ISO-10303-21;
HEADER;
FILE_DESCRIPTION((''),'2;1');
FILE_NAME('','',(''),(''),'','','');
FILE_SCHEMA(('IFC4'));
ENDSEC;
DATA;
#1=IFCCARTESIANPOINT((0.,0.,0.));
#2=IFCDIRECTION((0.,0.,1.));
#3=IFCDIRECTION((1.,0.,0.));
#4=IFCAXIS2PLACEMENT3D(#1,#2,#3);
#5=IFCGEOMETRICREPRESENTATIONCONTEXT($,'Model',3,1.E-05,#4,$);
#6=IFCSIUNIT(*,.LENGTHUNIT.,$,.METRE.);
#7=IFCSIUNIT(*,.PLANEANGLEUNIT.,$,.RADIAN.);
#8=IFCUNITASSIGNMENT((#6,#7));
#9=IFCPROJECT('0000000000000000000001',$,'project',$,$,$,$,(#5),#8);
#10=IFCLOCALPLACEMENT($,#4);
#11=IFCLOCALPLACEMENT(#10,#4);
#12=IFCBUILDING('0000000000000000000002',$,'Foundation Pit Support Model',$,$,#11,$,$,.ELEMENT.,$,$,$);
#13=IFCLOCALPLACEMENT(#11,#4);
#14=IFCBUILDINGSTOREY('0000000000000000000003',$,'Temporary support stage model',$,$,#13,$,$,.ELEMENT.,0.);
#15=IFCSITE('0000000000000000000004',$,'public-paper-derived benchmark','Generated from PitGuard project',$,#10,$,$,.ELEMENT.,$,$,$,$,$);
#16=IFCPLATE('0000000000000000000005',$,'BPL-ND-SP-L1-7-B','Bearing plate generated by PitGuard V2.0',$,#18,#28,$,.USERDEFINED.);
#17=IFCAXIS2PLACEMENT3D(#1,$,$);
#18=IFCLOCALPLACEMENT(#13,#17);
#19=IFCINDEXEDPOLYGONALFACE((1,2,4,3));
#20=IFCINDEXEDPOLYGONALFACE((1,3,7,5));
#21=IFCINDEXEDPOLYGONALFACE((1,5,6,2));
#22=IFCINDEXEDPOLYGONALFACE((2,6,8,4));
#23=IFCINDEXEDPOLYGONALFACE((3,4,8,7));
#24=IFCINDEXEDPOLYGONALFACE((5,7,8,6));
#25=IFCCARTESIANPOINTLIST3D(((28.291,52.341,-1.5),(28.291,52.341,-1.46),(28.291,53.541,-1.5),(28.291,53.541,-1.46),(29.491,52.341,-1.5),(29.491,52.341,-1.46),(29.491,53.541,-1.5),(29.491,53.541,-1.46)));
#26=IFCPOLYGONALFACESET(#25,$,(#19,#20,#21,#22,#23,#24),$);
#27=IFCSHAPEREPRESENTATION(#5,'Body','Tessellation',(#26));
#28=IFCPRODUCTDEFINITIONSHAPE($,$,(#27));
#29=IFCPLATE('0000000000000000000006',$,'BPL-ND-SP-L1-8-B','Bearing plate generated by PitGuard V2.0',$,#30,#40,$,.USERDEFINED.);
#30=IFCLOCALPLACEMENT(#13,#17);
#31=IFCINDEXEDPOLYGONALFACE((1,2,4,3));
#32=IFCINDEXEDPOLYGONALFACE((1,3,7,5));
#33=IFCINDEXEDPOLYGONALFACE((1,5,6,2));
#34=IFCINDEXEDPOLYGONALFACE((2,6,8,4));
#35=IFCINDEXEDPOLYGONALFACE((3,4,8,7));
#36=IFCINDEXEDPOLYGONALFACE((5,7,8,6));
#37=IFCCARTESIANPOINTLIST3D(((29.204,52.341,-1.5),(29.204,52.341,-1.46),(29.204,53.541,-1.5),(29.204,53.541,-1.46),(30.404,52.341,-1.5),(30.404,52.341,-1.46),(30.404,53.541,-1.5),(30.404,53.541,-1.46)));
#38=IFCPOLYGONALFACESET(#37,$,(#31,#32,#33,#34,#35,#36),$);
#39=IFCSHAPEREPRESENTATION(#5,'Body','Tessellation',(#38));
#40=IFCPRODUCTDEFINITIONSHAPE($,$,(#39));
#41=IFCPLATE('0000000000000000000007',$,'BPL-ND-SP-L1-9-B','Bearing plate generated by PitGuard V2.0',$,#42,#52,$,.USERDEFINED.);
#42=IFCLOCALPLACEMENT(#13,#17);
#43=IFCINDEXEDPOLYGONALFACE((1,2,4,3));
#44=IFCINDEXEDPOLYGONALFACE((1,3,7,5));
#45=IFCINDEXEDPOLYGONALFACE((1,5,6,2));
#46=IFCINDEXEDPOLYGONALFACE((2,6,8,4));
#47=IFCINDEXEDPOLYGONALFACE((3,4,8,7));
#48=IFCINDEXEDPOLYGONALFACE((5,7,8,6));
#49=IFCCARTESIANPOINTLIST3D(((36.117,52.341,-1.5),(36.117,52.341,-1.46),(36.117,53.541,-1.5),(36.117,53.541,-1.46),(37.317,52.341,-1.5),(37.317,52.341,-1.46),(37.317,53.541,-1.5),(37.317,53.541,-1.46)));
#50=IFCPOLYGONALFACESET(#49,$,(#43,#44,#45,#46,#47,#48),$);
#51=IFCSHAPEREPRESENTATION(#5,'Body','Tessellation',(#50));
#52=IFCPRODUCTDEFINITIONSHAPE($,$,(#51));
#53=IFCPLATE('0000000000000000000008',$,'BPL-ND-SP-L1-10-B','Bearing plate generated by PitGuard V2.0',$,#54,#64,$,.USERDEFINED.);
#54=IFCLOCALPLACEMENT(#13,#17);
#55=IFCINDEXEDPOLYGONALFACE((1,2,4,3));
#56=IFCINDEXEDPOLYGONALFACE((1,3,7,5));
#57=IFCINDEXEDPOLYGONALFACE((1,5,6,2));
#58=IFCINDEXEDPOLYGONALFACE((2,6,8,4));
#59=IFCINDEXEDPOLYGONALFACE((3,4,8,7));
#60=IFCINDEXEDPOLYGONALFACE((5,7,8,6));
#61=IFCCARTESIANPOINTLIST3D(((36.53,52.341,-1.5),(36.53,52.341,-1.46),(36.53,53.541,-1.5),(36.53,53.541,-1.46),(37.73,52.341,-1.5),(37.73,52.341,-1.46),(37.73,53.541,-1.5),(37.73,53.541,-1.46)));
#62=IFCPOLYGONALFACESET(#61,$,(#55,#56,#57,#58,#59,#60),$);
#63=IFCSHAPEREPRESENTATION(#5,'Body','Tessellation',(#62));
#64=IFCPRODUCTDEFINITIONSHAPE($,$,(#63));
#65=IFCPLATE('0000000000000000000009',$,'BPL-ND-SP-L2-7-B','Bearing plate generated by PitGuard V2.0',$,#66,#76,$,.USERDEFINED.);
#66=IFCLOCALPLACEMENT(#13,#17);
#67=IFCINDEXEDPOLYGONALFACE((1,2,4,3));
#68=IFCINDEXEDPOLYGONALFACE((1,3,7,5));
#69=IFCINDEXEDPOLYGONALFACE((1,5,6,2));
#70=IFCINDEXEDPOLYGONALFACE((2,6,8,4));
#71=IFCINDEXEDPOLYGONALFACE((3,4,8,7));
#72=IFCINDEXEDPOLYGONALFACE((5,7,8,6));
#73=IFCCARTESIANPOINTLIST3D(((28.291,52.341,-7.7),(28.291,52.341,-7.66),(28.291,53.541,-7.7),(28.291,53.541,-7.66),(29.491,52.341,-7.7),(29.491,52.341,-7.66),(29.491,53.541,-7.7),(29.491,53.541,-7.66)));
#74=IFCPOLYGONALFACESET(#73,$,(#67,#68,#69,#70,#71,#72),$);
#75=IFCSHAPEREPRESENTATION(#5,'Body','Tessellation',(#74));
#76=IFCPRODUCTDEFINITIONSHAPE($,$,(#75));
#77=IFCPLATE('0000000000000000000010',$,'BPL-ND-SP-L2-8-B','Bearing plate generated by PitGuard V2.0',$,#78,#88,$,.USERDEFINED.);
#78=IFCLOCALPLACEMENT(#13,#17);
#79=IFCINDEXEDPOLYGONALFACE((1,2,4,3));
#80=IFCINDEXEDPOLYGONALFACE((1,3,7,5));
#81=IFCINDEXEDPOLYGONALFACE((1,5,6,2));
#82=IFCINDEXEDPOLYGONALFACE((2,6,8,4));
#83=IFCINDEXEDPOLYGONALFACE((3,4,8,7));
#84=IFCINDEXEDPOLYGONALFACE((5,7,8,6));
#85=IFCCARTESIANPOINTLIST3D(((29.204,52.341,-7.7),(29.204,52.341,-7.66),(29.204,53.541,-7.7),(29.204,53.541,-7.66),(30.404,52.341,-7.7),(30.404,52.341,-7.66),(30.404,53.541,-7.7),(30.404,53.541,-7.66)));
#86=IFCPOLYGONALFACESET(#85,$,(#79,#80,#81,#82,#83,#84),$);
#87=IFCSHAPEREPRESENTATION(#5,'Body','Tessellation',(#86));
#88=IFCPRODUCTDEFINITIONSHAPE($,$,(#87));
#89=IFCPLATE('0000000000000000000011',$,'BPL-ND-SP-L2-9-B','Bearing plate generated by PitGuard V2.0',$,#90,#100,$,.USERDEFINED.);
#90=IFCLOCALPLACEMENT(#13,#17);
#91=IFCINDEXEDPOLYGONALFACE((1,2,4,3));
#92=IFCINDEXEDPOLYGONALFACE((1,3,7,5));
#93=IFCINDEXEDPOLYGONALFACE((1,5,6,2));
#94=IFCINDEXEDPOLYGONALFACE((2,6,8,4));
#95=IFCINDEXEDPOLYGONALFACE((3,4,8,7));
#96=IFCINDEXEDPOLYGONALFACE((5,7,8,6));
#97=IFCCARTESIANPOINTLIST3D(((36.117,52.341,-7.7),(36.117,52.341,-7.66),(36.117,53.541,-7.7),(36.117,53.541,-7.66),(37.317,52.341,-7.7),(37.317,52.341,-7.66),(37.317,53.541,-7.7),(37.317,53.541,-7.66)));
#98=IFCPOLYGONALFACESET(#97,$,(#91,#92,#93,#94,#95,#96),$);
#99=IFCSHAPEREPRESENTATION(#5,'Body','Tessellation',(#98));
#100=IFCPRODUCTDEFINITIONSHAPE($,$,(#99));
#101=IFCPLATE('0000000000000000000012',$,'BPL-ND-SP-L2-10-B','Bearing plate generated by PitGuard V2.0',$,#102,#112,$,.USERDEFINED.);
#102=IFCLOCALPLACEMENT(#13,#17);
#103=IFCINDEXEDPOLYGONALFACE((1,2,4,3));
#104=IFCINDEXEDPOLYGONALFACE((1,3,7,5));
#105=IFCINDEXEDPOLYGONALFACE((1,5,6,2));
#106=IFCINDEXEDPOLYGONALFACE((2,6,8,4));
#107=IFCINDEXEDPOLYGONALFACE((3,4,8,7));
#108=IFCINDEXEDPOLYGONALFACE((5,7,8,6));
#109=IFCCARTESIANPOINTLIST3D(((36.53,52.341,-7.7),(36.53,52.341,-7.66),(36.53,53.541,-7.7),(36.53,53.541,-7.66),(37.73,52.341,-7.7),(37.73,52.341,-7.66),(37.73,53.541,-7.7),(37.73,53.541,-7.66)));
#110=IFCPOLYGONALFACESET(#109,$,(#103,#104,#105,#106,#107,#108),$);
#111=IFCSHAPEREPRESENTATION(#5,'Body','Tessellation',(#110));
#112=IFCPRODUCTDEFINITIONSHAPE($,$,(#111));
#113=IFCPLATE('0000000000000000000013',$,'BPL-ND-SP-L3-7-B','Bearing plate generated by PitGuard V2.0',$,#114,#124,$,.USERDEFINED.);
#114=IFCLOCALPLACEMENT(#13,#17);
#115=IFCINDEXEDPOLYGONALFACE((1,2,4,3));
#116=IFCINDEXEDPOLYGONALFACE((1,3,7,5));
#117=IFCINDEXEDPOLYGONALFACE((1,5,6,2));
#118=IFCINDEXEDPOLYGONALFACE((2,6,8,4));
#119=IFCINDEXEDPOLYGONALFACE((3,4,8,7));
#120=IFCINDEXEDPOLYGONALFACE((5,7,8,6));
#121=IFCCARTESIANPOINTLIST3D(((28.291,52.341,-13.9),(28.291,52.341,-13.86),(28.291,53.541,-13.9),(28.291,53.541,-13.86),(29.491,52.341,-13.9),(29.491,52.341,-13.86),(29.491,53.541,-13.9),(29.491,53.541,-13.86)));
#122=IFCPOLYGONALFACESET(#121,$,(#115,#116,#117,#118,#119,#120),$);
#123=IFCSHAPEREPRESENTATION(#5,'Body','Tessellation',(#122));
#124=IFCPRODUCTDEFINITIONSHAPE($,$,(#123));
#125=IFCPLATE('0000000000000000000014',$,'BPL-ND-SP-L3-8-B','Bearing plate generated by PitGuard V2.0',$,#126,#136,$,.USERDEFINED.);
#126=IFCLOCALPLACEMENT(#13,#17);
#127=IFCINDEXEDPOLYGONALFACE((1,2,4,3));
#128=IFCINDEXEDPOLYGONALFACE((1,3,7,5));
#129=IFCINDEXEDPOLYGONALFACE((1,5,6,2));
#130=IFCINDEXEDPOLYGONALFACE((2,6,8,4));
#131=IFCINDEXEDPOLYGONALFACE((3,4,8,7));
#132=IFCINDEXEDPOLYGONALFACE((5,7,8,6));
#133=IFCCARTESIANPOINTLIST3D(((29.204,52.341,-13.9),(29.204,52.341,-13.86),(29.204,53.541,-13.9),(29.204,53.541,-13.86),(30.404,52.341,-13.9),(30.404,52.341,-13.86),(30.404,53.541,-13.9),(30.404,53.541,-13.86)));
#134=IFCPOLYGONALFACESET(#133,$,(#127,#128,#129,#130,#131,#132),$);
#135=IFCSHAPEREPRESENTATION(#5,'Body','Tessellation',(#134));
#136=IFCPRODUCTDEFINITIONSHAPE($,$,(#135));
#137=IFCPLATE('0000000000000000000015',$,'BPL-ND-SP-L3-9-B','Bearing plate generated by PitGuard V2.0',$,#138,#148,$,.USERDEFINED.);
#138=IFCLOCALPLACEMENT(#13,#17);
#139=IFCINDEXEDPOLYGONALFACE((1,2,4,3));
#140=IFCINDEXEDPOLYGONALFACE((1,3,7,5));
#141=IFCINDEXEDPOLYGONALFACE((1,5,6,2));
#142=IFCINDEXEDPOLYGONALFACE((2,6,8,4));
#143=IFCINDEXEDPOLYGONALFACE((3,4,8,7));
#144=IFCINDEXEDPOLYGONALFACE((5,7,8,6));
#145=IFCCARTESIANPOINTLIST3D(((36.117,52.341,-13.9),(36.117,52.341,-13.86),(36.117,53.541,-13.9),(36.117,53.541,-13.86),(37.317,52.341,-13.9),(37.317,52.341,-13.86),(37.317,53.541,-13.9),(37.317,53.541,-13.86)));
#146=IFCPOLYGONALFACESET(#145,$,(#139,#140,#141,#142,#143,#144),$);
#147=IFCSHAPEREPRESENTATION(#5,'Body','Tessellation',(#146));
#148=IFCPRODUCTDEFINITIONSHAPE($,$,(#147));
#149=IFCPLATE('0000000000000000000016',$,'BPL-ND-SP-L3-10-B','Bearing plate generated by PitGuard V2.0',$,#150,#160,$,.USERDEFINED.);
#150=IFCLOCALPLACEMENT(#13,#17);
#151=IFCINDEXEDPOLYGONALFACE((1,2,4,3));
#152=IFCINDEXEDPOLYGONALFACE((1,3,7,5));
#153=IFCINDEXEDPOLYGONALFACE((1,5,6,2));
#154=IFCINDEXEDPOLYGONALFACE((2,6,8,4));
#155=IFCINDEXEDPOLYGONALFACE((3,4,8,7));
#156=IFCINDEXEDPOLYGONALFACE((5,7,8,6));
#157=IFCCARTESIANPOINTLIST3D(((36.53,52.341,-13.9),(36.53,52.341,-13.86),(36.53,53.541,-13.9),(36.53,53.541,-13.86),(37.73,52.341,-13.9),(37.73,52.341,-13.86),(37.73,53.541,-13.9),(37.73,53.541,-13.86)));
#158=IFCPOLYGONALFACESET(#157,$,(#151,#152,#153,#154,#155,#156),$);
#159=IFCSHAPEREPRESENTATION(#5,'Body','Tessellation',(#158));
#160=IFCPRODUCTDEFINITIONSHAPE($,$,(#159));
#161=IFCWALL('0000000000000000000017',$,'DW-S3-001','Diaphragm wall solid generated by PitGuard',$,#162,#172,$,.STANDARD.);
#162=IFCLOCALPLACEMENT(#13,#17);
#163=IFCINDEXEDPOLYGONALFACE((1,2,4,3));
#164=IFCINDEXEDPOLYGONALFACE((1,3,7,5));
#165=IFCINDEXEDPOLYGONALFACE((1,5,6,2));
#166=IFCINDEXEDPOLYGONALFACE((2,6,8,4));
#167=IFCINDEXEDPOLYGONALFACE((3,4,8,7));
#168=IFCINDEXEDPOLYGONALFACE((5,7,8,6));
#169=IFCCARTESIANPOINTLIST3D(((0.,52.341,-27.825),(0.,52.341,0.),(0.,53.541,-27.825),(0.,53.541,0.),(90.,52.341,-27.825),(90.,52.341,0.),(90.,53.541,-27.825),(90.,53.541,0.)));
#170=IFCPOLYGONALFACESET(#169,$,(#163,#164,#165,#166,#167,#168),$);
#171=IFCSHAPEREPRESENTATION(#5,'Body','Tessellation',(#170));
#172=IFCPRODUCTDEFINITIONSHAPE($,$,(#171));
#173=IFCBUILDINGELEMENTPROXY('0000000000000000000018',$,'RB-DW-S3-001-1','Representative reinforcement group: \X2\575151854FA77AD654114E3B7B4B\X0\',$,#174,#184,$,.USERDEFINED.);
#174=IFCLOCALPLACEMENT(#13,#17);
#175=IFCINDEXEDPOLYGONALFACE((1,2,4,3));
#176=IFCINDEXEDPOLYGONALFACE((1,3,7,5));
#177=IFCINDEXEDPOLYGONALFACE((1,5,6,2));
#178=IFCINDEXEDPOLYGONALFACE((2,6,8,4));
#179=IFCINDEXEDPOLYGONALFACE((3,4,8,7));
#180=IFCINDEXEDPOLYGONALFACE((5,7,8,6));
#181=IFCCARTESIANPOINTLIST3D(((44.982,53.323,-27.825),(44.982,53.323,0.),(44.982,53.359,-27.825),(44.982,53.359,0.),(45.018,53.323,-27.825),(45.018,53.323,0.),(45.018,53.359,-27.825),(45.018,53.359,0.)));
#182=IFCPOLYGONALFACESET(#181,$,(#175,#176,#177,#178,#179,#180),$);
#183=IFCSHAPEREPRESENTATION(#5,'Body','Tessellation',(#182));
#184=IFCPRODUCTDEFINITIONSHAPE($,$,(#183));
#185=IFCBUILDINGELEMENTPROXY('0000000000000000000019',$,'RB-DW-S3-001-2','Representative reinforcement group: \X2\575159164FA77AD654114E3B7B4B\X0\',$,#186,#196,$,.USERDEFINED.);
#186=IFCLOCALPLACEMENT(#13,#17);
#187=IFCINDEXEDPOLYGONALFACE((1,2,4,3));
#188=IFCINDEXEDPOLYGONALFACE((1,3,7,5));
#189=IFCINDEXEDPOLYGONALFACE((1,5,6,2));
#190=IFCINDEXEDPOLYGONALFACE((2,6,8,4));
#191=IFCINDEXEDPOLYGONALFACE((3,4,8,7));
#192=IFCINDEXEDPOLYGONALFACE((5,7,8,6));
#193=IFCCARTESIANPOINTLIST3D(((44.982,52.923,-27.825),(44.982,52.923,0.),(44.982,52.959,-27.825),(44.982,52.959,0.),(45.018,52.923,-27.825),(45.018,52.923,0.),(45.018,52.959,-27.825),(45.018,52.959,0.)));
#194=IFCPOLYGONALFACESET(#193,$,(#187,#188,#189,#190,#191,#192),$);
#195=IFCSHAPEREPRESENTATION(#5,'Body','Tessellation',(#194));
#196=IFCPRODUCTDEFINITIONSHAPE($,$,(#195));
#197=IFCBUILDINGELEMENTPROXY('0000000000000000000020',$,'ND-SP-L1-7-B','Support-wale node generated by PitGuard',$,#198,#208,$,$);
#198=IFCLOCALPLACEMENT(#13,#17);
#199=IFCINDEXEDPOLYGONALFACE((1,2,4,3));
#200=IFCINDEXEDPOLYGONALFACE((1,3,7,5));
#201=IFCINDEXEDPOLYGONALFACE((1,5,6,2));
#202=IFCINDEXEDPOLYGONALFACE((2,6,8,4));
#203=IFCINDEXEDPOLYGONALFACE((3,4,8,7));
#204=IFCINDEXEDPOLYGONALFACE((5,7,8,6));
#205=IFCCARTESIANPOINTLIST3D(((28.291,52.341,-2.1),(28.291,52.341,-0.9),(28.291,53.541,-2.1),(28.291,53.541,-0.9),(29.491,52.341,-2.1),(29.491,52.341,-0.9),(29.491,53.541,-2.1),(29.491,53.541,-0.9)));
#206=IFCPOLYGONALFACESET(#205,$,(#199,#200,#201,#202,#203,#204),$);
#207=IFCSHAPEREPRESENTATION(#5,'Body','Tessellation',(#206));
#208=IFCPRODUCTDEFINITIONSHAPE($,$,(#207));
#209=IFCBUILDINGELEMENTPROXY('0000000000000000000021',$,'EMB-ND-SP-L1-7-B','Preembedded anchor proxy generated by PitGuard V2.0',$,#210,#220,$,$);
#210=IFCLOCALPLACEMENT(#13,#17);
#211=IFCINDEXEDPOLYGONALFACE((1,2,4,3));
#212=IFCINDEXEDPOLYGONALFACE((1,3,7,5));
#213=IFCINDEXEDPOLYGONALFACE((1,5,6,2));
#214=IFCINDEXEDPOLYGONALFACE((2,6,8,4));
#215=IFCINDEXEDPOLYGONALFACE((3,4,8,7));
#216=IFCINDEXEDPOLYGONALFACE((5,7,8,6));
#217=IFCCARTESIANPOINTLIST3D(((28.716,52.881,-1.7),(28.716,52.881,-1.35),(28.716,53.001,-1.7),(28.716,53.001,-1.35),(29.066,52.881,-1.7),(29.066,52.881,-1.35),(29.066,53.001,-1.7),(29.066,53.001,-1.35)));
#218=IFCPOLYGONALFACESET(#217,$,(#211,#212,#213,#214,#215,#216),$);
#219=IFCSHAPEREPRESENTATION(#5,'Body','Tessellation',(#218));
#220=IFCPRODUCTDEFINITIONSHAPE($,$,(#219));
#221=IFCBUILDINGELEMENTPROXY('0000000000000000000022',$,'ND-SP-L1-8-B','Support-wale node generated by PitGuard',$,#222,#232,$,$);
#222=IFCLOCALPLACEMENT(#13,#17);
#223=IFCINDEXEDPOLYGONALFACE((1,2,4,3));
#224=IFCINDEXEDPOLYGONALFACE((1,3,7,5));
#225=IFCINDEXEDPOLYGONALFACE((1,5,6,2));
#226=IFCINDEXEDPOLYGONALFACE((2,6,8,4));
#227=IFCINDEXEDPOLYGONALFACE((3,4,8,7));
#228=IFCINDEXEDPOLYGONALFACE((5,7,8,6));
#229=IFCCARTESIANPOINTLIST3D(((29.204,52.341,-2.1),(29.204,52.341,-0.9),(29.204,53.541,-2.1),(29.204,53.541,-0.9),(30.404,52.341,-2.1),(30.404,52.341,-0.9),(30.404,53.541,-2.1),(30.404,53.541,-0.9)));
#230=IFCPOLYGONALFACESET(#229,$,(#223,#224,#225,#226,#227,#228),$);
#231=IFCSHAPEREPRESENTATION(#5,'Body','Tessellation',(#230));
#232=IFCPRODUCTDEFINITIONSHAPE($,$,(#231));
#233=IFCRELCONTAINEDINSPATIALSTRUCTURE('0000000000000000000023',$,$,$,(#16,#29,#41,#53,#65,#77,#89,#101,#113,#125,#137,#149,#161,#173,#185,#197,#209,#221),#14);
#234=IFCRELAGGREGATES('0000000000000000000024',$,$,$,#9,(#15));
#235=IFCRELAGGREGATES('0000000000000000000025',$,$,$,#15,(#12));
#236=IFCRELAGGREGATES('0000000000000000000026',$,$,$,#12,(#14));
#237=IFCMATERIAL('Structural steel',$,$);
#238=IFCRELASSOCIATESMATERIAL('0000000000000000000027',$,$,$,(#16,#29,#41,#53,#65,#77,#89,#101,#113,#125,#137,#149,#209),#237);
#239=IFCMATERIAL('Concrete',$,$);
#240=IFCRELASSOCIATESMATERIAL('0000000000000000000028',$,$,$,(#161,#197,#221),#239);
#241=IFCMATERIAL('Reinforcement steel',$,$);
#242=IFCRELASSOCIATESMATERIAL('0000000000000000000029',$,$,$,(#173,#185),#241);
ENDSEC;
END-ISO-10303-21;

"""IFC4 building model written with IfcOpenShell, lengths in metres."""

from ifc_helpers import new_model, si_unit, frame, origin_with_axes, origin_2d, place, context, project, spatial, rectangle, extrude, material, element, save


model = new_model("IFC4")

# Units and contexts
model_context = context("Model", 3, precision=1e-05, world=origin_with_axes())
ifc_project = project(units=[si_unit("LENGTHUNIT", "METRE"), si_unit("PLANEANGLEUNIT", "RADIAN")], contexts=[model_context])

# Site, building, storey
site_placement = place(None, origin_with_axes())
site = spatial("IfcSite", under=ifc_project, at=site_placement, Name="public-paper-derived benchmark", Description="Generated from PitGuard project", CompositionType="ELEMENT")
building_placement = place(site_placement, origin_with_axes())
building = spatial("IfcBuilding", under=site, at=building_placement, Name="Foundation Pit Support Model", CompositionType="ELEMENT")
storey_placement = place(building_placement, origin_with_axes())
storey = spatial("IfcBuildingStorey", under=building, at=storey_placement, Name="Temporary support stage model", CompositionType="ELEMENT", Elevation=0.0)

# Plates
ifc_material_1 = material(Name="Structural steel")
for number, where, z_axis, x_axis, name in (
    (1, (28.891, 52.941, -1.5), (0.0, 0.0, 1.0), (1.0, 0.0, 0.0), "BPL-ND-SP-L1-7-B"),
    (2, (29.804, 52.941, -1.5), (0.0, 0.0, 1.0), (1.0, 0.0, 0.0), "BPL-ND-SP-L1-8-B"),
    (3, (36.717, 52.941, -1.5), (0.0, 0.0, 1.0), (1.0, 0.0, 0.0), "BPL-ND-SP-L1-9-B"),
    (4, (37.13, 52.941, -1.5), (0.0, 0.0, 1.0), (1.0, 0.0, 0.0), "BPL-ND-SP-L1-10-B"),
    (5, (28.891, 52.941, -7.7), (0.0, 0.0, 1.0), (1.0, 0.0, 0.0), "BPL-ND-SP-L2-7-B"),
    (6, (29.804, 52.941, -7.7), (0.0, 0.0, 1.0), (1.0, 0.0, 0.0), "BPL-ND-SP-L2-8-B"),
    (7, (36.717, 52.941, -7.7), (0.0, 0.0, 1.0), (1.0, 0.0, 0.0), "BPL-ND-SP-L2-9-B"),
    (8, (37.13, 52.941, -7.7), (0.0, 0.0, 1.0), (1.0, 0.0, 0.0), "BPL-ND-SP-L2-10-B"),
    (9, (28.891, 52.941, -13.9), (0.0, 0.0, 1.0), (1.0, 0.0, 0.0), "BPL-ND-SP-L3-7-B"),
    (10, (29.804, 52.941, -13.9), (0.0, 0.0, 1.0), (1.0, 0.0, 0.0), "BPL-ND-SP-L3-8-B"),
    (11, (36.717, 52.941, -13.9), (0.0, 0.0, 1.0), (1.0, 0.0, 0.0), "BPL-ND-SP-L3-9-B"),
    (12, (37.13, 52.941, -13.9), (0.0, 0.0, 1.0), (1.0, 0.0, 0.0), "BPL-ND-SP-L3-10-B"),
):
    element("IfcPlate", number, at=place(storey_placement, frame(where, z_axis=z_axis, x_axis=x_axis)), inside=storey, material=ifc_material_1, Name=name, Description="Bearing plate generated by PitGuard V2.0", PredefinedType="USERDEFINED", context=model_context, shape_type="SweptSolid", body=[
        extrude(rectangle(XDim=1.2, YDim=1.2, at=origin_2d()), origin_with_axes(), (0.0, 0.0, 1.0), 0.04),
    ])

# Wall
ifc_material_2 = material(Name="Concrete")
wall_placement = place(storey_placement, frame((45.0, 52.941, -27.825), z_axis=(0.0, 0.0, 1.0), x_axis=(-1.0, 0.0, 0.0)))
element("IfcWall", 13, at=wall_placement, inside=storey, material=ifc_material_2, Name="DW-S3-001", Description="Diaphragm wall solid generated by PitGuard", PredefinedType="STANDARD", context=model_context, shape_type="SweptSolid", body=[
    extrude(rectangle(XDim=90.0, YDim=1.2, at=origin_2d()), origin_with_axes(), (0.0, 0.0, 1.0), 27.825),
])

# Building element proxies
ifc_material_3 = material(Name="Reinforcement steel")
for number, where, z_axis, x_axis, name, description in (
    (14, (45.0, 53.341, -27.825), (0.0, 0.0, 1.0), (1.0, 0.0, 0.0), "RB-DW-S3-001-1", "Representative reinforcement group: 坑内侧竖向主筋"),
    (15, (45.0, 52.941, -27.825), (0.0, 0.0, 1.0), (1.0, 0.0, 0.0), "RB-DW-S3-001-2", "Representative reinforcement group: 坑外侧竖向主筋"),
):
    element("IfcBuildingElementProxy", number, at=place(storey_placement, frame(where, z_axis=z_axis, x_axis=x_axis)), inside=storey, material=ifc_material_3, Name=name, Description=description, PredefinedType="USERDEFINED", context=model_context, shape_type="SweptSolid", body=[
        extrude(rectangle(XDim=0.036, YDim=0.036, at=origin_2d()), origin_with_axes(), (0.0, 0.0, 1.0), 27.825),
    ])
proxy_1_placement = place(storey_placement, frame((28.891, 52.941, -2.1), z_axis=(0.0, 0.0, 1.0), x_axis=(1.0, 0.0, 0.0)))
element("IfcBuildingElementProxy", 16, at=proxy_1_placement, inside=storey, material=ifc_material_2, Name="ND-SP-L1-7-B", Description="Support-wale node generated by PitGuard", context=model_context, shape_type="SweptSolid", body=[
    extrude(rectangle(XDim=1.2, YDim=1.2, at=origin_2d()), origin_with_axes(), (0.0, 0.0, 1.0), 1.2),
])
proxy_2_placement = place(storey_placement, frame((28.891, 52.941, -1.7), z_axis=(0.0, 0.0, 1.0), x_axis=(1.0, 0.0, 0.0)))
element("IfcBuildingElementProxy", 17, at=proxy_2_placement, inside=storey, material=ifc_material_1, Name="EMB-ND-SP-L1-7-B", Description="Preembedded anchor proxy generated by PitGuard V2.0", context=model_context, shape_type="SweptSolid", body=[
    extrude(rectangle(XDim=0.35, YDim=0.12, at=origin_2d()), origin_with_axes(), (0.0, 0.0, 1.0), 0.35),
])
proxy_3_placement = place(storey_placement, frame((29.804, 52.941, -2.1), z_axis=(0.0, 0.0, 1.0), x_axis=(1.0, 0.0, 0.0)))
element("IfcBuildingElementProxy", 18, at=proxy_3_placement, inside=storey, material=ifc_material_2, Name="ND-SP-L1-8-B", Description="Support-wale node generated by PitGuard", context=model_context, shape_type="SweptSolid", body=[
    extrude(rectangle(XDim=1.2, YDim=1.2, at=origin_2d()), origin_with_axes(), (0.0, 0.0, 1.0), 1.2),
])

save(model, "model.ifc")
